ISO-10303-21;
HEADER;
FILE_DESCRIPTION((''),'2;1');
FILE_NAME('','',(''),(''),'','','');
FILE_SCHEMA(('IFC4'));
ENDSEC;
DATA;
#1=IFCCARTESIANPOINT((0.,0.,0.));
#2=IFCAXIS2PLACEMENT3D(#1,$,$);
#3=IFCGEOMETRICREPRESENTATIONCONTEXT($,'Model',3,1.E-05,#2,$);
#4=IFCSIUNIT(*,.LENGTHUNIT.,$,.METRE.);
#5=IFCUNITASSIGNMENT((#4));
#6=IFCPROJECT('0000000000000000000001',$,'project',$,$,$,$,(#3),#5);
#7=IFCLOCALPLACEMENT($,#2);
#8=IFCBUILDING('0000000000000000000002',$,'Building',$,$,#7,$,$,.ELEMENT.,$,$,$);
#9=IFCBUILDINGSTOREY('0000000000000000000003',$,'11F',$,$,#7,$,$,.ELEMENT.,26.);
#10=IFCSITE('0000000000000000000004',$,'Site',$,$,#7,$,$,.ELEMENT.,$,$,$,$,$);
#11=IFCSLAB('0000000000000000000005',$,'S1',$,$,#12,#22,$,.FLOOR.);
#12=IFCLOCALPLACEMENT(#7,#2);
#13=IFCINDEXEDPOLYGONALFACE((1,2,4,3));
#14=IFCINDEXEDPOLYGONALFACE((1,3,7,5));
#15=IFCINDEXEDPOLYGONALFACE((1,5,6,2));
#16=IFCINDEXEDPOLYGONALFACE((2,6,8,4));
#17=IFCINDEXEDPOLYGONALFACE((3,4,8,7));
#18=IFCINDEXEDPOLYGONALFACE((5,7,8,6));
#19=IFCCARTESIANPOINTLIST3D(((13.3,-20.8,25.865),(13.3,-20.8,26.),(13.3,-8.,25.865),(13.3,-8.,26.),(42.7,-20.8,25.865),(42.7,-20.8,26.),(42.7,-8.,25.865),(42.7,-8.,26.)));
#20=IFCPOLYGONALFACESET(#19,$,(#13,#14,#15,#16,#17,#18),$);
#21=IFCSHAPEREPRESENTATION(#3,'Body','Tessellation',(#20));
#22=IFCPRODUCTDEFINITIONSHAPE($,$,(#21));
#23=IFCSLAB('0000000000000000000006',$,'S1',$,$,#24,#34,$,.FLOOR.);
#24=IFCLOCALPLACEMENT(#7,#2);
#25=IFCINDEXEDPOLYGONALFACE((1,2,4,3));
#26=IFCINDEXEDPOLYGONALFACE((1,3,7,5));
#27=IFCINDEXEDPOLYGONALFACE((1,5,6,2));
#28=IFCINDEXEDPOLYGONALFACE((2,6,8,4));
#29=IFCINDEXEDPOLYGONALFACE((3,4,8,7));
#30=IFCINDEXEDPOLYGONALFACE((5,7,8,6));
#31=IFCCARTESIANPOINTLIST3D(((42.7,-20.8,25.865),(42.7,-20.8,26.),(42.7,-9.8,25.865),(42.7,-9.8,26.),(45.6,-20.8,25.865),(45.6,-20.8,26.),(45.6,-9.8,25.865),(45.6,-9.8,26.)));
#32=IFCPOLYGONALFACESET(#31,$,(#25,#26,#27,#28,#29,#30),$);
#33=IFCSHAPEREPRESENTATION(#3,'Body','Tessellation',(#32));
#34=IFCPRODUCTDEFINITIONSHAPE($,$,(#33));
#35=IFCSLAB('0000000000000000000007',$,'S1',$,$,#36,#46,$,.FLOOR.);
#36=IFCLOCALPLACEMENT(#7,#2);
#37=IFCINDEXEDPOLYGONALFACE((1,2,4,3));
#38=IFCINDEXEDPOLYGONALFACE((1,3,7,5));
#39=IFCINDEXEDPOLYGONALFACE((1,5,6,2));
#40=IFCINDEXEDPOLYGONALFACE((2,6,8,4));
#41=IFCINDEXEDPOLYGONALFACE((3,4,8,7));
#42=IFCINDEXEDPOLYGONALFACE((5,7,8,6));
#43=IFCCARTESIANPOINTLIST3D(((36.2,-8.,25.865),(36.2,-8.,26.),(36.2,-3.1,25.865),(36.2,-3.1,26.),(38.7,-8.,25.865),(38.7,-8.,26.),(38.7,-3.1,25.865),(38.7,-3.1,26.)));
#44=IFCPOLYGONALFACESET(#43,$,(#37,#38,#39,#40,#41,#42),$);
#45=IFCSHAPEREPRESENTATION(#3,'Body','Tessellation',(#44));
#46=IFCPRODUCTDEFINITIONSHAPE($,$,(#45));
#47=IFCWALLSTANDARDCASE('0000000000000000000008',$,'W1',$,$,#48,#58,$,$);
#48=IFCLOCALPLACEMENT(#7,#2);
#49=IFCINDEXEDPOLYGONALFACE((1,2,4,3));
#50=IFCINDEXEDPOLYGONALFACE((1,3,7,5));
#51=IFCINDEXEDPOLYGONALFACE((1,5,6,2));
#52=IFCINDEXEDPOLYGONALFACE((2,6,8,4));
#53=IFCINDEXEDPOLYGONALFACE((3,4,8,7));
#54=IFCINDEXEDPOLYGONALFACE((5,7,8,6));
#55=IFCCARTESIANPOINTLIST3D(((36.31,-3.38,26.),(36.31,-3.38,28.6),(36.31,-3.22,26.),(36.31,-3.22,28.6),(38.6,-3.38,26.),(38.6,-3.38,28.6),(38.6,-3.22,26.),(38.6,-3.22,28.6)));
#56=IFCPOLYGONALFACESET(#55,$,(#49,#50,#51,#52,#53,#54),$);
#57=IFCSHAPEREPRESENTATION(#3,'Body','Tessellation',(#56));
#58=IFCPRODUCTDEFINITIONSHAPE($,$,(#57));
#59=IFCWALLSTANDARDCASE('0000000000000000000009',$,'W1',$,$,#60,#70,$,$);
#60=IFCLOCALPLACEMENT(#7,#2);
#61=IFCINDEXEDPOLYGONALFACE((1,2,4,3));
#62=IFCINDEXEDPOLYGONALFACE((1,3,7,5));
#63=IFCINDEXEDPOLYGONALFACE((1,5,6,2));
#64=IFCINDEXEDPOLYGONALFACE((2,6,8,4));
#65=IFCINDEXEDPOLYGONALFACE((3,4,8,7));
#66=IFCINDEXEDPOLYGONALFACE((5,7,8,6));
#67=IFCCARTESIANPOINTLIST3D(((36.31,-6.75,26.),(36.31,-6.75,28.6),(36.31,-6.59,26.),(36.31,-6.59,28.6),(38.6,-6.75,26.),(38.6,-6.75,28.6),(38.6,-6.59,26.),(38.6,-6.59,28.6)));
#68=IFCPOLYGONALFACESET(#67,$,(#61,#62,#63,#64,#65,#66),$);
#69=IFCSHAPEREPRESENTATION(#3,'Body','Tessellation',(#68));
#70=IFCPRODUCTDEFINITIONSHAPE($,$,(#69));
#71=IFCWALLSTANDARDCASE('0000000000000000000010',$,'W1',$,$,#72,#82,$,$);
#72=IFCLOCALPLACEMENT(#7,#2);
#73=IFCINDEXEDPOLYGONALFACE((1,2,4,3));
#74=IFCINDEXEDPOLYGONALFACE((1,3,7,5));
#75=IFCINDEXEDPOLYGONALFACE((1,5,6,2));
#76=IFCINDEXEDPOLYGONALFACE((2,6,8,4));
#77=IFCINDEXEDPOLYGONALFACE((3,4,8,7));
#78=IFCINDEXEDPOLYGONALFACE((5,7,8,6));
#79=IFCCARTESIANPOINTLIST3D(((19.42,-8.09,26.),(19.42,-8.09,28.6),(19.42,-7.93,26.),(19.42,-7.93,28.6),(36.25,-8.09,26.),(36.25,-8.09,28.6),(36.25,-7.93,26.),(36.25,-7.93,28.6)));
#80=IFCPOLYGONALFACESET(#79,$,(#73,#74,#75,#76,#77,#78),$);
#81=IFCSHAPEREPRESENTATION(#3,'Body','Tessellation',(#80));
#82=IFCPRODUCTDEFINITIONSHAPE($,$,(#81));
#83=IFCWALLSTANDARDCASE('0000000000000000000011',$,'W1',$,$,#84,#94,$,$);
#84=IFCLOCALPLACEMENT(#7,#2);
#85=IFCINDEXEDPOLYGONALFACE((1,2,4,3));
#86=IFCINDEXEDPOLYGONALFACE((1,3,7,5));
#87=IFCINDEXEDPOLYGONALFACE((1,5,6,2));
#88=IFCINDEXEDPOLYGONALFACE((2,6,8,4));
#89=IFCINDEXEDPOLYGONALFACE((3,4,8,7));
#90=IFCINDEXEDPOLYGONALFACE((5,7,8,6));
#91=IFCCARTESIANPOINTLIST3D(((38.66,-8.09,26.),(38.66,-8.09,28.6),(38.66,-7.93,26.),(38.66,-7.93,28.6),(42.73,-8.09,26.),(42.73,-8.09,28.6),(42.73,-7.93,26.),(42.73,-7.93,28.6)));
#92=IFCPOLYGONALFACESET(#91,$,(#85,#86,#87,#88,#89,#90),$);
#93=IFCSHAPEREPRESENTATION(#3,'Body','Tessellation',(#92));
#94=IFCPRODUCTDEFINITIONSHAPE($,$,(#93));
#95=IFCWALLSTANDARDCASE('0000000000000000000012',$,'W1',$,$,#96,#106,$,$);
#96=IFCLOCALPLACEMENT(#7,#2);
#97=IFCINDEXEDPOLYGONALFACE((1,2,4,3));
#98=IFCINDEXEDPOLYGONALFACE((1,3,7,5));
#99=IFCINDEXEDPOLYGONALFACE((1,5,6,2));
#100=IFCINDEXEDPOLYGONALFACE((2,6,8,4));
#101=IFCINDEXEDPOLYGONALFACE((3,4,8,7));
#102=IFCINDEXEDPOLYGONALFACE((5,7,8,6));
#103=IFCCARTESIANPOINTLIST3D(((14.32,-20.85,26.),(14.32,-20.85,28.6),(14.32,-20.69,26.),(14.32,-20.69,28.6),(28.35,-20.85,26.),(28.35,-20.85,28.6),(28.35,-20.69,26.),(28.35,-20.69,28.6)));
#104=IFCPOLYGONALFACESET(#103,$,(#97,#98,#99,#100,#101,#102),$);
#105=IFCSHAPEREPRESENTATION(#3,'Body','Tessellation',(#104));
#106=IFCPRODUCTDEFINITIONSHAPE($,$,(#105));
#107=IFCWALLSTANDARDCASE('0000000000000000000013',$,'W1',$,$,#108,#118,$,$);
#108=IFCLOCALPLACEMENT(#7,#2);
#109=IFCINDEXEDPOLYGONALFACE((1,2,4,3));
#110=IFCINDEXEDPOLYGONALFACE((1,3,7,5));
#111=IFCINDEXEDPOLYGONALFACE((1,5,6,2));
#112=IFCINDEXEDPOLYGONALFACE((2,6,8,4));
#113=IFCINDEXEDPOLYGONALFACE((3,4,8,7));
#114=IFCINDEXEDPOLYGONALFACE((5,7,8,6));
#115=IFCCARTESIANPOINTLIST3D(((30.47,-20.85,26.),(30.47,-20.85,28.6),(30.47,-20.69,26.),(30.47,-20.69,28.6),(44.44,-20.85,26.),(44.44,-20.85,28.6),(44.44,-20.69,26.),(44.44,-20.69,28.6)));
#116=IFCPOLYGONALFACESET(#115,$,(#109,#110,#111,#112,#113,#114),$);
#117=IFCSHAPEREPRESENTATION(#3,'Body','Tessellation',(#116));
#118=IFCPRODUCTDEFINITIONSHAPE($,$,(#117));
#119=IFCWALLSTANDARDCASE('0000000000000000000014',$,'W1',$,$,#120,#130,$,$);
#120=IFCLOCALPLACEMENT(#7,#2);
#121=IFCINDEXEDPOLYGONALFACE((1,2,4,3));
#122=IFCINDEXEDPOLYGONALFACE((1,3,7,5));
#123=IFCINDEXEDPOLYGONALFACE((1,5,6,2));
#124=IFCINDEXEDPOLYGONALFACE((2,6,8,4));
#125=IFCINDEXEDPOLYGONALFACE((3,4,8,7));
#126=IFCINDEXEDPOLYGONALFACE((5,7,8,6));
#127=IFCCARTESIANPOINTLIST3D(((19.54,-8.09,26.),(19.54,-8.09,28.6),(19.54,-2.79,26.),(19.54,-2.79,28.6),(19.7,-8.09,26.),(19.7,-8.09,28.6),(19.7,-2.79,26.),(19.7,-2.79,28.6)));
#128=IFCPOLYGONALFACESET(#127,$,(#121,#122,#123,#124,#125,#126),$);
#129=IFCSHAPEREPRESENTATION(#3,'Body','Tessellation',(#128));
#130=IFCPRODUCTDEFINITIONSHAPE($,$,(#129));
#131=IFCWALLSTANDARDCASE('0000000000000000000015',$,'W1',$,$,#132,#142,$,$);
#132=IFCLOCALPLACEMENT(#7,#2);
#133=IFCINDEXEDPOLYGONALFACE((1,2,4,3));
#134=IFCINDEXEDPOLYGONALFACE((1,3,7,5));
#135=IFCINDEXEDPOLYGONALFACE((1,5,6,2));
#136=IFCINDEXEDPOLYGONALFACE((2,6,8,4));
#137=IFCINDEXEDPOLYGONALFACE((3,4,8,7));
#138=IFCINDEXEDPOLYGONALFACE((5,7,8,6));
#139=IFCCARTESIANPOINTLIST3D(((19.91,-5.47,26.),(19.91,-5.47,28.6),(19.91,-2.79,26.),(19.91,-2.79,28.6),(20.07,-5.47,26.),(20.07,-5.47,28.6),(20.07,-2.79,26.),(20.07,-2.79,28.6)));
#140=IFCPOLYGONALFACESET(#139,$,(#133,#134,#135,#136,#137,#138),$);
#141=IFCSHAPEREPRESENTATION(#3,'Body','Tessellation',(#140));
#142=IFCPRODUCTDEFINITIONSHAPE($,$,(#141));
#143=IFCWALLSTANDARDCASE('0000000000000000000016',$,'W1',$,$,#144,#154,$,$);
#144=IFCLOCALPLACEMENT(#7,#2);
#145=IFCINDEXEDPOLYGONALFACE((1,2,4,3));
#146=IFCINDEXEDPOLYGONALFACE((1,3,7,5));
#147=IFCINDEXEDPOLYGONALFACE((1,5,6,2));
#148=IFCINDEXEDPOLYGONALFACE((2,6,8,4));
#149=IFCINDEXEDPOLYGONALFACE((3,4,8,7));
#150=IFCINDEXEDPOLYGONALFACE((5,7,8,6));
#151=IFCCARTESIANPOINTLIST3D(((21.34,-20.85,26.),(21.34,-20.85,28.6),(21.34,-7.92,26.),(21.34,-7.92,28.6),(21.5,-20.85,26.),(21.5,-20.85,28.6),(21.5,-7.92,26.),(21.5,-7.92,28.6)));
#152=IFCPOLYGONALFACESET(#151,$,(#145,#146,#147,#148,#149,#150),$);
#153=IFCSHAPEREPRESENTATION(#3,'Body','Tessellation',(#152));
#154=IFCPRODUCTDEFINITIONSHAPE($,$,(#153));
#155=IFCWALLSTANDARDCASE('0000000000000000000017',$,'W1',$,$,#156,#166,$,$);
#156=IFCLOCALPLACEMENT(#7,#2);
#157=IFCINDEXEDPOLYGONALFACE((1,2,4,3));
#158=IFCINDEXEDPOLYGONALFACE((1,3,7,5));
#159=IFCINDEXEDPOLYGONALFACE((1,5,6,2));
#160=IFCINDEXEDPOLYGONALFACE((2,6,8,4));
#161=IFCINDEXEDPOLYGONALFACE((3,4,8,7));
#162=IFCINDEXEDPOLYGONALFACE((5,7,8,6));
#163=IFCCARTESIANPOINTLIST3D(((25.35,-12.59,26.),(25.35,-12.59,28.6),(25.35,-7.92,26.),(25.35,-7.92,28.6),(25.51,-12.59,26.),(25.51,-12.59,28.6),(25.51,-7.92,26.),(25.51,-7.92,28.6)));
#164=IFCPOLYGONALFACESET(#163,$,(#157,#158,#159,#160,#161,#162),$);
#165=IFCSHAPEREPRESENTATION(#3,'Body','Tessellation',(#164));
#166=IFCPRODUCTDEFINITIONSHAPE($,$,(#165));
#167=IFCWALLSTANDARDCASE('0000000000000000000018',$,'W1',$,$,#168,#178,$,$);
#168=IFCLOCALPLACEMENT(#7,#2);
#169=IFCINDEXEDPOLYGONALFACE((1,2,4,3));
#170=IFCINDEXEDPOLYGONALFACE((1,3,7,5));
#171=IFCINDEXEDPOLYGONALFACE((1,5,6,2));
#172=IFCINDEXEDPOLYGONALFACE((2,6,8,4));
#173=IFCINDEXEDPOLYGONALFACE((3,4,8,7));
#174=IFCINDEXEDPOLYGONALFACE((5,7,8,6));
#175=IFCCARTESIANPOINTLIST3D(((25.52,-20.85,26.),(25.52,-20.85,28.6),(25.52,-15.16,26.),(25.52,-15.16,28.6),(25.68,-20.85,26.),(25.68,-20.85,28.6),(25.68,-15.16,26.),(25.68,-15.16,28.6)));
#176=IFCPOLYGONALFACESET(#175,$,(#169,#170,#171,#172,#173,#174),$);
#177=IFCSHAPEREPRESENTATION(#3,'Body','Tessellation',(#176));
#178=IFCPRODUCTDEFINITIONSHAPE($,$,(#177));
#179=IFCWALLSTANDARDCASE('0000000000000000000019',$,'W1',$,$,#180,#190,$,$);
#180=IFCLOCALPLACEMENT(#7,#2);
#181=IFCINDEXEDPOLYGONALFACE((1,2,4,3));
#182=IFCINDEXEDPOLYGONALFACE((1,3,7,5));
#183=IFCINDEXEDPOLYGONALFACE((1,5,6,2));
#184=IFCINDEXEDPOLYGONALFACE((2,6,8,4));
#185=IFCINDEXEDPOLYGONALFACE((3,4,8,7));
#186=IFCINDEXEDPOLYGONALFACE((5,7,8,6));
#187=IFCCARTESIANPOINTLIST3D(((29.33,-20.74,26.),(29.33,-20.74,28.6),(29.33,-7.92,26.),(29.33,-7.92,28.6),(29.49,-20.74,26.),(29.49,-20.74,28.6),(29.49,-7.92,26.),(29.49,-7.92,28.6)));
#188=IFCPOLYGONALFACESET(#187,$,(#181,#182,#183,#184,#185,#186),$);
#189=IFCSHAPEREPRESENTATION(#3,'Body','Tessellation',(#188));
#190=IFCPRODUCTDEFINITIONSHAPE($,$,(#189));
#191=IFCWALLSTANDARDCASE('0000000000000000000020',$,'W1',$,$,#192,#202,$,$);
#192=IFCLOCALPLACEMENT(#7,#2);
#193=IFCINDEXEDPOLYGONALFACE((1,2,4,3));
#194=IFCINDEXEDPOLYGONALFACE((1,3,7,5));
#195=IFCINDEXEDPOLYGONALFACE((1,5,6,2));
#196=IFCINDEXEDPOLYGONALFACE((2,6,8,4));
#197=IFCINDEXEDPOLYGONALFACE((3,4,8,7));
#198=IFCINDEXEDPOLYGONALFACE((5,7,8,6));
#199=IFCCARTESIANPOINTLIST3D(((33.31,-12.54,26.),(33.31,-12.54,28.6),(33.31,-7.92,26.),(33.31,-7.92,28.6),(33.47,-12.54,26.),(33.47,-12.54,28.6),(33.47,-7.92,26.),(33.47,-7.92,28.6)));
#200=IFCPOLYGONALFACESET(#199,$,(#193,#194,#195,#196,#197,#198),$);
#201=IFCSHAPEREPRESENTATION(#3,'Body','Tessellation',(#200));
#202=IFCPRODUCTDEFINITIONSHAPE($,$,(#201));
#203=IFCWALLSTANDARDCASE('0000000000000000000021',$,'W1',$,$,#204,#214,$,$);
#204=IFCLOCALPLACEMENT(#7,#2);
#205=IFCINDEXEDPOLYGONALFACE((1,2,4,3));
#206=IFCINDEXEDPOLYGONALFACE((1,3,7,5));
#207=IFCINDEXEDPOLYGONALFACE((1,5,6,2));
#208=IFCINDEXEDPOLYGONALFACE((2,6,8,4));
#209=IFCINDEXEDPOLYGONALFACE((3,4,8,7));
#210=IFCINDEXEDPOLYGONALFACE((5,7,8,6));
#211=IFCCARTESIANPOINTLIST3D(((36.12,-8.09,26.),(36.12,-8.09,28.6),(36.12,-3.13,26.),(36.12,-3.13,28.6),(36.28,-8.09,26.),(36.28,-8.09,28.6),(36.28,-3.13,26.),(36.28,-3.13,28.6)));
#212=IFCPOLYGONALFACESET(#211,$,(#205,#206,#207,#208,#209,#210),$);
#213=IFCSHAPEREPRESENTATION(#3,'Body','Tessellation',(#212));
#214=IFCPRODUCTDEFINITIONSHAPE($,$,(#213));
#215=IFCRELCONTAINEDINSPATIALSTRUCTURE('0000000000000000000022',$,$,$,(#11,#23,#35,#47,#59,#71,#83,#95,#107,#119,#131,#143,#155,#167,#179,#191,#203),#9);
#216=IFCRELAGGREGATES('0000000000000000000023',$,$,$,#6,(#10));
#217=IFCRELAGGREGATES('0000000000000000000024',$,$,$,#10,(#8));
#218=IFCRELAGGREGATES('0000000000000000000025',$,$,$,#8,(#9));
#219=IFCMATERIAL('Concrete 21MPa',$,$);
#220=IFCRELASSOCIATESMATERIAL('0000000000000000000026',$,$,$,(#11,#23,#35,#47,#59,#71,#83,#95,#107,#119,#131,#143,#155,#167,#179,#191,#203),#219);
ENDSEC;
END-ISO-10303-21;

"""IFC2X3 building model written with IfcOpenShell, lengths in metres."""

from ifc_helpers import new_model, si_unit, frame, origin, origin_2d, place, context, project, spatial, rectangle, extrude, material, element, save


model = new_model("IFC2X3")

# Units and contexts
model_context = context("Model", 3, precision=1e-05, world=origin())
ifc_project = project(units=[si_unit("LENGTHUNIT", "METRE")], contexts=[model_context])

# Site, building, storey
placement = place(None, origin())
site = spatial("IfcSite", under=ifc_project, at=placement, Name="Site", CompositionType="ELEMENT")
building = spatial("IfcBuilding", under=site, at=placement, Name="Building", CompositionType="ELEMENT")
storey = spatial("IfcBuildingStorey", under=building, at=placement, Name="11F", CompositionType="ELEMENT", Elevation=26.0)

# Slabs
ifc_material_1 = material(Name="Concrete 21MPa")
slab_1_placement = place(None, frame((28.0, -14.4, 25.865)))
element("IfcSlab", 1, at=slab_1_placement, inside=storey, material=ifc_material_1, Name="S1", PredefinedType="FLOOR", context=model_context, shape_type="SweptSolid", body=[
    extrude(rectangle(XDim=29.4, YDim=12.8, at=origin_2d()), origin(), (0.0, 0.0, 1.0), 0.135),
])
slab_2_placement = place(None, frame((44.15, -15.3, 25.865)))
element("IfcSlab", 2, at=slab_2_placement, inside=storey, material=ifc_material_1, Name="S1", PredefinedType="FLOOR", context=model_context, shape_type="SweptSolid", body=[
    extrude(rectangle(XDim=2.9, YDim=11.0, at=origin_2d()), origin(), (0.0, 0.0, 1.0), 0.135),
])
slab_3_placement = place(None, frame((37.45, -5.55, 25.865)))
element("IfcSlab", 3, at=slab_3_placement, inside=storey, material=ifc_material_1, Name="S1", PredefinedType="FLOOR", context=model_context, shape_type="SweptSolid", body=[
    extrude(rectangle(XDim=2.5, YDim=4.9, at=origin_2d()), origin(), (0.0, 0.0, 1.0), 0.135),
])

# Walls
for number, where, name in (
    (4, (37.455, -3.3, 26.0), "W1"),
    (5, (37.455, -6.67, 26.0), "W1"),
):
    element("IfcWallStandardCase", number, at=place(None, frame(where)), inside=storey, material=ifc_material_1, Name=name, context=model_context, shape_type="SweptSolid", body=[
        extrude(rectangle(XDim=2.29, YDim=0.16, at=origin_2d()), origin(), (0.0, 0.0, 1.0), 2.6),
    ])
wall_1_placement = place(None, frame((27.835, -8.01, 26.0)))
element("IfcWallStandardCase", 6, at=wall_1_placement, inside=storey, material=ifc_material_1, Name="W1", context=model_context, shape_type="SweptSolid", body=[
    extrude(rectangle(XDim=16.83, YDim=0.16, at=origin_2d()), origin(), (0.0, 0.0, 1.0), 2.6),
])
wall_2_placement = place(None, frame((40.695, -8.01, 26.0)))
element("IfcWallStandardCase", 7, at=wall_2_placement, inside=storey, material=ifc_material_1, Name="W1", context=model_context, shape_type="SweptSolid", body=[
    extrude(rectangle(XDim=4.07, YDim=0.16, at=origin_2d()), origin(), (0.0, 0.0, 1.0), 2.6),
])
wall_3_placement = place(None, frame((21.335, -20.77, 26.0)))
element("IfcWallStandardCase", 8, at=wall_3_placement, inside=storey, material=ifc_material_1, Name="W1", context=model_context, shape_type="SweptSolid", body=[
    extrude(rectangle(XDim=14.03, YDim=0.16, at=origin_2d()), origin(), (0.0, 0.0, 1.0), 2.6),
])
wall_4_placement = place(None, frame((37.455, -20.77, 26.0)))
element("IfcWallStandardCase", 9, at=wall_4_placement, inside=storey, material=ifc_material_1, Name="W1", context=model_context, shape_type="SweptSolid", body=[
    extrude(rectangle(XDim=13.97, YDim=0.16, at=origin_2d()), origin(), (0.0, 0.0, 1.0), 2.6),
])
wall_5_placement = place(None, frame((19.62, -5.44, 26.0)))
element("IfcWallStandardCase", 10, at=wall_5_placement, inside=storey, material=ifc_material_1, Name="W1", context=model_context, shape_type="SweptSolid", body=[
    extrude(rectangle(XDim=0.16, YDim=5.3, at=origin_2d()), origin(), (0.0, 0.0, 1.0), 2.6),
])
wall_6_placement = place(None, frame((19.99, -4.13, 26.0)))
element("IfcWallStandardCase", 11, at=wall_6_placement, inside=storey, material=ifc_material_1, Name="W1", context=model_context, shape_type="SweptSolid", body=[
    extrude(rectangle(XDim=0.16, YDim=2.68, at=origin_2d()), origin(), (0.0, 0.0, 1.0), 2.6),
])
wall_7_placement = place(None, frame((21.42, -14.385, 26.0)))
element("IfcWallStandardCase", 12, at=wall_7_placement, inside=storey, material=ifc_material_1, Name="W1", context=model_context, shape_type="SweptSolid", body=[
    extrude(rectangle(XDim=0.16, YDim=12.93, at=origin_2d()), origin(), (0.0, 0.0, 1.0), 2.6),
])
wall_8_placement = place(None, frame((25.43, -10.255, 26.0)))
element("IfcWallStandardCase", 13, at=wall_8_placement, inside=storey, material=ifc_material_1, Name="W1", context=model_context, shape_type="SweptSolid", body=[
    extrude(rectangle(XDim=0.16, YDim=4.67, at=origin_2d()), origin(), (0.0, 0.0, 1.0), 2.6),
])
wall_9_placement = place(None, frame((25.6, -18.005, 26.0)))
element("IfcWallStandardCase", 14, at=wall_9_placement, inside=storey, material=ifc_material_1, Name="W1", context=model_context, shape_type="SweptSolid", body=[
    extrude(rectangle(XDim=0.16, YDim=5.69, at=origin_2d()), origin(), (0.0, 0.0, 1.0), 2.6),
])
wall_10_placement = place(None, frame((29.41, -14.33, 26.0)))
element("IfcWallStandardCase", 15, at=wall_10_placement, inside=storey, material=ifc_material_1, Name="W1", context=model_context, shape_type="SweptSolid", body=[
    extrude(rectangle(XDim=0.16, YDim=12.82, at=origin_2d()), origin(), (0.0, 0.0, 1.0), 2.6),
])
wall_11_placement = place(None, frame((33.39, -10.23, 26.0)))
element("IfcWallStandardCase", 16, at=wall_11_placement, inside=storey, material=ifc_material_1, Name="W1", context=model_context, shape_type="SweptSolid", body=[
    extrude(rectangle(XDim=0.16, YDim=4.62, at=origin_2d()), origin(), (0.0, 0.0, 1.0), 2.6),
])
wall_12_placement = place(None, frame((36.2, -5.61, 26.0)))
element("IfcWallStandardCase", 17, at=wall_12_placement, inside=storey, material=ifc_material_1, Name="W1", context=model_context, shape_type="SweptSolid", body=[
    extrude(rectangle(XDim=0.16, YDim=4.96, at=origin_2d()), origin(), (0.0, 0.0, 1.0), 2.6),
])

save(model, "model.ifc")
